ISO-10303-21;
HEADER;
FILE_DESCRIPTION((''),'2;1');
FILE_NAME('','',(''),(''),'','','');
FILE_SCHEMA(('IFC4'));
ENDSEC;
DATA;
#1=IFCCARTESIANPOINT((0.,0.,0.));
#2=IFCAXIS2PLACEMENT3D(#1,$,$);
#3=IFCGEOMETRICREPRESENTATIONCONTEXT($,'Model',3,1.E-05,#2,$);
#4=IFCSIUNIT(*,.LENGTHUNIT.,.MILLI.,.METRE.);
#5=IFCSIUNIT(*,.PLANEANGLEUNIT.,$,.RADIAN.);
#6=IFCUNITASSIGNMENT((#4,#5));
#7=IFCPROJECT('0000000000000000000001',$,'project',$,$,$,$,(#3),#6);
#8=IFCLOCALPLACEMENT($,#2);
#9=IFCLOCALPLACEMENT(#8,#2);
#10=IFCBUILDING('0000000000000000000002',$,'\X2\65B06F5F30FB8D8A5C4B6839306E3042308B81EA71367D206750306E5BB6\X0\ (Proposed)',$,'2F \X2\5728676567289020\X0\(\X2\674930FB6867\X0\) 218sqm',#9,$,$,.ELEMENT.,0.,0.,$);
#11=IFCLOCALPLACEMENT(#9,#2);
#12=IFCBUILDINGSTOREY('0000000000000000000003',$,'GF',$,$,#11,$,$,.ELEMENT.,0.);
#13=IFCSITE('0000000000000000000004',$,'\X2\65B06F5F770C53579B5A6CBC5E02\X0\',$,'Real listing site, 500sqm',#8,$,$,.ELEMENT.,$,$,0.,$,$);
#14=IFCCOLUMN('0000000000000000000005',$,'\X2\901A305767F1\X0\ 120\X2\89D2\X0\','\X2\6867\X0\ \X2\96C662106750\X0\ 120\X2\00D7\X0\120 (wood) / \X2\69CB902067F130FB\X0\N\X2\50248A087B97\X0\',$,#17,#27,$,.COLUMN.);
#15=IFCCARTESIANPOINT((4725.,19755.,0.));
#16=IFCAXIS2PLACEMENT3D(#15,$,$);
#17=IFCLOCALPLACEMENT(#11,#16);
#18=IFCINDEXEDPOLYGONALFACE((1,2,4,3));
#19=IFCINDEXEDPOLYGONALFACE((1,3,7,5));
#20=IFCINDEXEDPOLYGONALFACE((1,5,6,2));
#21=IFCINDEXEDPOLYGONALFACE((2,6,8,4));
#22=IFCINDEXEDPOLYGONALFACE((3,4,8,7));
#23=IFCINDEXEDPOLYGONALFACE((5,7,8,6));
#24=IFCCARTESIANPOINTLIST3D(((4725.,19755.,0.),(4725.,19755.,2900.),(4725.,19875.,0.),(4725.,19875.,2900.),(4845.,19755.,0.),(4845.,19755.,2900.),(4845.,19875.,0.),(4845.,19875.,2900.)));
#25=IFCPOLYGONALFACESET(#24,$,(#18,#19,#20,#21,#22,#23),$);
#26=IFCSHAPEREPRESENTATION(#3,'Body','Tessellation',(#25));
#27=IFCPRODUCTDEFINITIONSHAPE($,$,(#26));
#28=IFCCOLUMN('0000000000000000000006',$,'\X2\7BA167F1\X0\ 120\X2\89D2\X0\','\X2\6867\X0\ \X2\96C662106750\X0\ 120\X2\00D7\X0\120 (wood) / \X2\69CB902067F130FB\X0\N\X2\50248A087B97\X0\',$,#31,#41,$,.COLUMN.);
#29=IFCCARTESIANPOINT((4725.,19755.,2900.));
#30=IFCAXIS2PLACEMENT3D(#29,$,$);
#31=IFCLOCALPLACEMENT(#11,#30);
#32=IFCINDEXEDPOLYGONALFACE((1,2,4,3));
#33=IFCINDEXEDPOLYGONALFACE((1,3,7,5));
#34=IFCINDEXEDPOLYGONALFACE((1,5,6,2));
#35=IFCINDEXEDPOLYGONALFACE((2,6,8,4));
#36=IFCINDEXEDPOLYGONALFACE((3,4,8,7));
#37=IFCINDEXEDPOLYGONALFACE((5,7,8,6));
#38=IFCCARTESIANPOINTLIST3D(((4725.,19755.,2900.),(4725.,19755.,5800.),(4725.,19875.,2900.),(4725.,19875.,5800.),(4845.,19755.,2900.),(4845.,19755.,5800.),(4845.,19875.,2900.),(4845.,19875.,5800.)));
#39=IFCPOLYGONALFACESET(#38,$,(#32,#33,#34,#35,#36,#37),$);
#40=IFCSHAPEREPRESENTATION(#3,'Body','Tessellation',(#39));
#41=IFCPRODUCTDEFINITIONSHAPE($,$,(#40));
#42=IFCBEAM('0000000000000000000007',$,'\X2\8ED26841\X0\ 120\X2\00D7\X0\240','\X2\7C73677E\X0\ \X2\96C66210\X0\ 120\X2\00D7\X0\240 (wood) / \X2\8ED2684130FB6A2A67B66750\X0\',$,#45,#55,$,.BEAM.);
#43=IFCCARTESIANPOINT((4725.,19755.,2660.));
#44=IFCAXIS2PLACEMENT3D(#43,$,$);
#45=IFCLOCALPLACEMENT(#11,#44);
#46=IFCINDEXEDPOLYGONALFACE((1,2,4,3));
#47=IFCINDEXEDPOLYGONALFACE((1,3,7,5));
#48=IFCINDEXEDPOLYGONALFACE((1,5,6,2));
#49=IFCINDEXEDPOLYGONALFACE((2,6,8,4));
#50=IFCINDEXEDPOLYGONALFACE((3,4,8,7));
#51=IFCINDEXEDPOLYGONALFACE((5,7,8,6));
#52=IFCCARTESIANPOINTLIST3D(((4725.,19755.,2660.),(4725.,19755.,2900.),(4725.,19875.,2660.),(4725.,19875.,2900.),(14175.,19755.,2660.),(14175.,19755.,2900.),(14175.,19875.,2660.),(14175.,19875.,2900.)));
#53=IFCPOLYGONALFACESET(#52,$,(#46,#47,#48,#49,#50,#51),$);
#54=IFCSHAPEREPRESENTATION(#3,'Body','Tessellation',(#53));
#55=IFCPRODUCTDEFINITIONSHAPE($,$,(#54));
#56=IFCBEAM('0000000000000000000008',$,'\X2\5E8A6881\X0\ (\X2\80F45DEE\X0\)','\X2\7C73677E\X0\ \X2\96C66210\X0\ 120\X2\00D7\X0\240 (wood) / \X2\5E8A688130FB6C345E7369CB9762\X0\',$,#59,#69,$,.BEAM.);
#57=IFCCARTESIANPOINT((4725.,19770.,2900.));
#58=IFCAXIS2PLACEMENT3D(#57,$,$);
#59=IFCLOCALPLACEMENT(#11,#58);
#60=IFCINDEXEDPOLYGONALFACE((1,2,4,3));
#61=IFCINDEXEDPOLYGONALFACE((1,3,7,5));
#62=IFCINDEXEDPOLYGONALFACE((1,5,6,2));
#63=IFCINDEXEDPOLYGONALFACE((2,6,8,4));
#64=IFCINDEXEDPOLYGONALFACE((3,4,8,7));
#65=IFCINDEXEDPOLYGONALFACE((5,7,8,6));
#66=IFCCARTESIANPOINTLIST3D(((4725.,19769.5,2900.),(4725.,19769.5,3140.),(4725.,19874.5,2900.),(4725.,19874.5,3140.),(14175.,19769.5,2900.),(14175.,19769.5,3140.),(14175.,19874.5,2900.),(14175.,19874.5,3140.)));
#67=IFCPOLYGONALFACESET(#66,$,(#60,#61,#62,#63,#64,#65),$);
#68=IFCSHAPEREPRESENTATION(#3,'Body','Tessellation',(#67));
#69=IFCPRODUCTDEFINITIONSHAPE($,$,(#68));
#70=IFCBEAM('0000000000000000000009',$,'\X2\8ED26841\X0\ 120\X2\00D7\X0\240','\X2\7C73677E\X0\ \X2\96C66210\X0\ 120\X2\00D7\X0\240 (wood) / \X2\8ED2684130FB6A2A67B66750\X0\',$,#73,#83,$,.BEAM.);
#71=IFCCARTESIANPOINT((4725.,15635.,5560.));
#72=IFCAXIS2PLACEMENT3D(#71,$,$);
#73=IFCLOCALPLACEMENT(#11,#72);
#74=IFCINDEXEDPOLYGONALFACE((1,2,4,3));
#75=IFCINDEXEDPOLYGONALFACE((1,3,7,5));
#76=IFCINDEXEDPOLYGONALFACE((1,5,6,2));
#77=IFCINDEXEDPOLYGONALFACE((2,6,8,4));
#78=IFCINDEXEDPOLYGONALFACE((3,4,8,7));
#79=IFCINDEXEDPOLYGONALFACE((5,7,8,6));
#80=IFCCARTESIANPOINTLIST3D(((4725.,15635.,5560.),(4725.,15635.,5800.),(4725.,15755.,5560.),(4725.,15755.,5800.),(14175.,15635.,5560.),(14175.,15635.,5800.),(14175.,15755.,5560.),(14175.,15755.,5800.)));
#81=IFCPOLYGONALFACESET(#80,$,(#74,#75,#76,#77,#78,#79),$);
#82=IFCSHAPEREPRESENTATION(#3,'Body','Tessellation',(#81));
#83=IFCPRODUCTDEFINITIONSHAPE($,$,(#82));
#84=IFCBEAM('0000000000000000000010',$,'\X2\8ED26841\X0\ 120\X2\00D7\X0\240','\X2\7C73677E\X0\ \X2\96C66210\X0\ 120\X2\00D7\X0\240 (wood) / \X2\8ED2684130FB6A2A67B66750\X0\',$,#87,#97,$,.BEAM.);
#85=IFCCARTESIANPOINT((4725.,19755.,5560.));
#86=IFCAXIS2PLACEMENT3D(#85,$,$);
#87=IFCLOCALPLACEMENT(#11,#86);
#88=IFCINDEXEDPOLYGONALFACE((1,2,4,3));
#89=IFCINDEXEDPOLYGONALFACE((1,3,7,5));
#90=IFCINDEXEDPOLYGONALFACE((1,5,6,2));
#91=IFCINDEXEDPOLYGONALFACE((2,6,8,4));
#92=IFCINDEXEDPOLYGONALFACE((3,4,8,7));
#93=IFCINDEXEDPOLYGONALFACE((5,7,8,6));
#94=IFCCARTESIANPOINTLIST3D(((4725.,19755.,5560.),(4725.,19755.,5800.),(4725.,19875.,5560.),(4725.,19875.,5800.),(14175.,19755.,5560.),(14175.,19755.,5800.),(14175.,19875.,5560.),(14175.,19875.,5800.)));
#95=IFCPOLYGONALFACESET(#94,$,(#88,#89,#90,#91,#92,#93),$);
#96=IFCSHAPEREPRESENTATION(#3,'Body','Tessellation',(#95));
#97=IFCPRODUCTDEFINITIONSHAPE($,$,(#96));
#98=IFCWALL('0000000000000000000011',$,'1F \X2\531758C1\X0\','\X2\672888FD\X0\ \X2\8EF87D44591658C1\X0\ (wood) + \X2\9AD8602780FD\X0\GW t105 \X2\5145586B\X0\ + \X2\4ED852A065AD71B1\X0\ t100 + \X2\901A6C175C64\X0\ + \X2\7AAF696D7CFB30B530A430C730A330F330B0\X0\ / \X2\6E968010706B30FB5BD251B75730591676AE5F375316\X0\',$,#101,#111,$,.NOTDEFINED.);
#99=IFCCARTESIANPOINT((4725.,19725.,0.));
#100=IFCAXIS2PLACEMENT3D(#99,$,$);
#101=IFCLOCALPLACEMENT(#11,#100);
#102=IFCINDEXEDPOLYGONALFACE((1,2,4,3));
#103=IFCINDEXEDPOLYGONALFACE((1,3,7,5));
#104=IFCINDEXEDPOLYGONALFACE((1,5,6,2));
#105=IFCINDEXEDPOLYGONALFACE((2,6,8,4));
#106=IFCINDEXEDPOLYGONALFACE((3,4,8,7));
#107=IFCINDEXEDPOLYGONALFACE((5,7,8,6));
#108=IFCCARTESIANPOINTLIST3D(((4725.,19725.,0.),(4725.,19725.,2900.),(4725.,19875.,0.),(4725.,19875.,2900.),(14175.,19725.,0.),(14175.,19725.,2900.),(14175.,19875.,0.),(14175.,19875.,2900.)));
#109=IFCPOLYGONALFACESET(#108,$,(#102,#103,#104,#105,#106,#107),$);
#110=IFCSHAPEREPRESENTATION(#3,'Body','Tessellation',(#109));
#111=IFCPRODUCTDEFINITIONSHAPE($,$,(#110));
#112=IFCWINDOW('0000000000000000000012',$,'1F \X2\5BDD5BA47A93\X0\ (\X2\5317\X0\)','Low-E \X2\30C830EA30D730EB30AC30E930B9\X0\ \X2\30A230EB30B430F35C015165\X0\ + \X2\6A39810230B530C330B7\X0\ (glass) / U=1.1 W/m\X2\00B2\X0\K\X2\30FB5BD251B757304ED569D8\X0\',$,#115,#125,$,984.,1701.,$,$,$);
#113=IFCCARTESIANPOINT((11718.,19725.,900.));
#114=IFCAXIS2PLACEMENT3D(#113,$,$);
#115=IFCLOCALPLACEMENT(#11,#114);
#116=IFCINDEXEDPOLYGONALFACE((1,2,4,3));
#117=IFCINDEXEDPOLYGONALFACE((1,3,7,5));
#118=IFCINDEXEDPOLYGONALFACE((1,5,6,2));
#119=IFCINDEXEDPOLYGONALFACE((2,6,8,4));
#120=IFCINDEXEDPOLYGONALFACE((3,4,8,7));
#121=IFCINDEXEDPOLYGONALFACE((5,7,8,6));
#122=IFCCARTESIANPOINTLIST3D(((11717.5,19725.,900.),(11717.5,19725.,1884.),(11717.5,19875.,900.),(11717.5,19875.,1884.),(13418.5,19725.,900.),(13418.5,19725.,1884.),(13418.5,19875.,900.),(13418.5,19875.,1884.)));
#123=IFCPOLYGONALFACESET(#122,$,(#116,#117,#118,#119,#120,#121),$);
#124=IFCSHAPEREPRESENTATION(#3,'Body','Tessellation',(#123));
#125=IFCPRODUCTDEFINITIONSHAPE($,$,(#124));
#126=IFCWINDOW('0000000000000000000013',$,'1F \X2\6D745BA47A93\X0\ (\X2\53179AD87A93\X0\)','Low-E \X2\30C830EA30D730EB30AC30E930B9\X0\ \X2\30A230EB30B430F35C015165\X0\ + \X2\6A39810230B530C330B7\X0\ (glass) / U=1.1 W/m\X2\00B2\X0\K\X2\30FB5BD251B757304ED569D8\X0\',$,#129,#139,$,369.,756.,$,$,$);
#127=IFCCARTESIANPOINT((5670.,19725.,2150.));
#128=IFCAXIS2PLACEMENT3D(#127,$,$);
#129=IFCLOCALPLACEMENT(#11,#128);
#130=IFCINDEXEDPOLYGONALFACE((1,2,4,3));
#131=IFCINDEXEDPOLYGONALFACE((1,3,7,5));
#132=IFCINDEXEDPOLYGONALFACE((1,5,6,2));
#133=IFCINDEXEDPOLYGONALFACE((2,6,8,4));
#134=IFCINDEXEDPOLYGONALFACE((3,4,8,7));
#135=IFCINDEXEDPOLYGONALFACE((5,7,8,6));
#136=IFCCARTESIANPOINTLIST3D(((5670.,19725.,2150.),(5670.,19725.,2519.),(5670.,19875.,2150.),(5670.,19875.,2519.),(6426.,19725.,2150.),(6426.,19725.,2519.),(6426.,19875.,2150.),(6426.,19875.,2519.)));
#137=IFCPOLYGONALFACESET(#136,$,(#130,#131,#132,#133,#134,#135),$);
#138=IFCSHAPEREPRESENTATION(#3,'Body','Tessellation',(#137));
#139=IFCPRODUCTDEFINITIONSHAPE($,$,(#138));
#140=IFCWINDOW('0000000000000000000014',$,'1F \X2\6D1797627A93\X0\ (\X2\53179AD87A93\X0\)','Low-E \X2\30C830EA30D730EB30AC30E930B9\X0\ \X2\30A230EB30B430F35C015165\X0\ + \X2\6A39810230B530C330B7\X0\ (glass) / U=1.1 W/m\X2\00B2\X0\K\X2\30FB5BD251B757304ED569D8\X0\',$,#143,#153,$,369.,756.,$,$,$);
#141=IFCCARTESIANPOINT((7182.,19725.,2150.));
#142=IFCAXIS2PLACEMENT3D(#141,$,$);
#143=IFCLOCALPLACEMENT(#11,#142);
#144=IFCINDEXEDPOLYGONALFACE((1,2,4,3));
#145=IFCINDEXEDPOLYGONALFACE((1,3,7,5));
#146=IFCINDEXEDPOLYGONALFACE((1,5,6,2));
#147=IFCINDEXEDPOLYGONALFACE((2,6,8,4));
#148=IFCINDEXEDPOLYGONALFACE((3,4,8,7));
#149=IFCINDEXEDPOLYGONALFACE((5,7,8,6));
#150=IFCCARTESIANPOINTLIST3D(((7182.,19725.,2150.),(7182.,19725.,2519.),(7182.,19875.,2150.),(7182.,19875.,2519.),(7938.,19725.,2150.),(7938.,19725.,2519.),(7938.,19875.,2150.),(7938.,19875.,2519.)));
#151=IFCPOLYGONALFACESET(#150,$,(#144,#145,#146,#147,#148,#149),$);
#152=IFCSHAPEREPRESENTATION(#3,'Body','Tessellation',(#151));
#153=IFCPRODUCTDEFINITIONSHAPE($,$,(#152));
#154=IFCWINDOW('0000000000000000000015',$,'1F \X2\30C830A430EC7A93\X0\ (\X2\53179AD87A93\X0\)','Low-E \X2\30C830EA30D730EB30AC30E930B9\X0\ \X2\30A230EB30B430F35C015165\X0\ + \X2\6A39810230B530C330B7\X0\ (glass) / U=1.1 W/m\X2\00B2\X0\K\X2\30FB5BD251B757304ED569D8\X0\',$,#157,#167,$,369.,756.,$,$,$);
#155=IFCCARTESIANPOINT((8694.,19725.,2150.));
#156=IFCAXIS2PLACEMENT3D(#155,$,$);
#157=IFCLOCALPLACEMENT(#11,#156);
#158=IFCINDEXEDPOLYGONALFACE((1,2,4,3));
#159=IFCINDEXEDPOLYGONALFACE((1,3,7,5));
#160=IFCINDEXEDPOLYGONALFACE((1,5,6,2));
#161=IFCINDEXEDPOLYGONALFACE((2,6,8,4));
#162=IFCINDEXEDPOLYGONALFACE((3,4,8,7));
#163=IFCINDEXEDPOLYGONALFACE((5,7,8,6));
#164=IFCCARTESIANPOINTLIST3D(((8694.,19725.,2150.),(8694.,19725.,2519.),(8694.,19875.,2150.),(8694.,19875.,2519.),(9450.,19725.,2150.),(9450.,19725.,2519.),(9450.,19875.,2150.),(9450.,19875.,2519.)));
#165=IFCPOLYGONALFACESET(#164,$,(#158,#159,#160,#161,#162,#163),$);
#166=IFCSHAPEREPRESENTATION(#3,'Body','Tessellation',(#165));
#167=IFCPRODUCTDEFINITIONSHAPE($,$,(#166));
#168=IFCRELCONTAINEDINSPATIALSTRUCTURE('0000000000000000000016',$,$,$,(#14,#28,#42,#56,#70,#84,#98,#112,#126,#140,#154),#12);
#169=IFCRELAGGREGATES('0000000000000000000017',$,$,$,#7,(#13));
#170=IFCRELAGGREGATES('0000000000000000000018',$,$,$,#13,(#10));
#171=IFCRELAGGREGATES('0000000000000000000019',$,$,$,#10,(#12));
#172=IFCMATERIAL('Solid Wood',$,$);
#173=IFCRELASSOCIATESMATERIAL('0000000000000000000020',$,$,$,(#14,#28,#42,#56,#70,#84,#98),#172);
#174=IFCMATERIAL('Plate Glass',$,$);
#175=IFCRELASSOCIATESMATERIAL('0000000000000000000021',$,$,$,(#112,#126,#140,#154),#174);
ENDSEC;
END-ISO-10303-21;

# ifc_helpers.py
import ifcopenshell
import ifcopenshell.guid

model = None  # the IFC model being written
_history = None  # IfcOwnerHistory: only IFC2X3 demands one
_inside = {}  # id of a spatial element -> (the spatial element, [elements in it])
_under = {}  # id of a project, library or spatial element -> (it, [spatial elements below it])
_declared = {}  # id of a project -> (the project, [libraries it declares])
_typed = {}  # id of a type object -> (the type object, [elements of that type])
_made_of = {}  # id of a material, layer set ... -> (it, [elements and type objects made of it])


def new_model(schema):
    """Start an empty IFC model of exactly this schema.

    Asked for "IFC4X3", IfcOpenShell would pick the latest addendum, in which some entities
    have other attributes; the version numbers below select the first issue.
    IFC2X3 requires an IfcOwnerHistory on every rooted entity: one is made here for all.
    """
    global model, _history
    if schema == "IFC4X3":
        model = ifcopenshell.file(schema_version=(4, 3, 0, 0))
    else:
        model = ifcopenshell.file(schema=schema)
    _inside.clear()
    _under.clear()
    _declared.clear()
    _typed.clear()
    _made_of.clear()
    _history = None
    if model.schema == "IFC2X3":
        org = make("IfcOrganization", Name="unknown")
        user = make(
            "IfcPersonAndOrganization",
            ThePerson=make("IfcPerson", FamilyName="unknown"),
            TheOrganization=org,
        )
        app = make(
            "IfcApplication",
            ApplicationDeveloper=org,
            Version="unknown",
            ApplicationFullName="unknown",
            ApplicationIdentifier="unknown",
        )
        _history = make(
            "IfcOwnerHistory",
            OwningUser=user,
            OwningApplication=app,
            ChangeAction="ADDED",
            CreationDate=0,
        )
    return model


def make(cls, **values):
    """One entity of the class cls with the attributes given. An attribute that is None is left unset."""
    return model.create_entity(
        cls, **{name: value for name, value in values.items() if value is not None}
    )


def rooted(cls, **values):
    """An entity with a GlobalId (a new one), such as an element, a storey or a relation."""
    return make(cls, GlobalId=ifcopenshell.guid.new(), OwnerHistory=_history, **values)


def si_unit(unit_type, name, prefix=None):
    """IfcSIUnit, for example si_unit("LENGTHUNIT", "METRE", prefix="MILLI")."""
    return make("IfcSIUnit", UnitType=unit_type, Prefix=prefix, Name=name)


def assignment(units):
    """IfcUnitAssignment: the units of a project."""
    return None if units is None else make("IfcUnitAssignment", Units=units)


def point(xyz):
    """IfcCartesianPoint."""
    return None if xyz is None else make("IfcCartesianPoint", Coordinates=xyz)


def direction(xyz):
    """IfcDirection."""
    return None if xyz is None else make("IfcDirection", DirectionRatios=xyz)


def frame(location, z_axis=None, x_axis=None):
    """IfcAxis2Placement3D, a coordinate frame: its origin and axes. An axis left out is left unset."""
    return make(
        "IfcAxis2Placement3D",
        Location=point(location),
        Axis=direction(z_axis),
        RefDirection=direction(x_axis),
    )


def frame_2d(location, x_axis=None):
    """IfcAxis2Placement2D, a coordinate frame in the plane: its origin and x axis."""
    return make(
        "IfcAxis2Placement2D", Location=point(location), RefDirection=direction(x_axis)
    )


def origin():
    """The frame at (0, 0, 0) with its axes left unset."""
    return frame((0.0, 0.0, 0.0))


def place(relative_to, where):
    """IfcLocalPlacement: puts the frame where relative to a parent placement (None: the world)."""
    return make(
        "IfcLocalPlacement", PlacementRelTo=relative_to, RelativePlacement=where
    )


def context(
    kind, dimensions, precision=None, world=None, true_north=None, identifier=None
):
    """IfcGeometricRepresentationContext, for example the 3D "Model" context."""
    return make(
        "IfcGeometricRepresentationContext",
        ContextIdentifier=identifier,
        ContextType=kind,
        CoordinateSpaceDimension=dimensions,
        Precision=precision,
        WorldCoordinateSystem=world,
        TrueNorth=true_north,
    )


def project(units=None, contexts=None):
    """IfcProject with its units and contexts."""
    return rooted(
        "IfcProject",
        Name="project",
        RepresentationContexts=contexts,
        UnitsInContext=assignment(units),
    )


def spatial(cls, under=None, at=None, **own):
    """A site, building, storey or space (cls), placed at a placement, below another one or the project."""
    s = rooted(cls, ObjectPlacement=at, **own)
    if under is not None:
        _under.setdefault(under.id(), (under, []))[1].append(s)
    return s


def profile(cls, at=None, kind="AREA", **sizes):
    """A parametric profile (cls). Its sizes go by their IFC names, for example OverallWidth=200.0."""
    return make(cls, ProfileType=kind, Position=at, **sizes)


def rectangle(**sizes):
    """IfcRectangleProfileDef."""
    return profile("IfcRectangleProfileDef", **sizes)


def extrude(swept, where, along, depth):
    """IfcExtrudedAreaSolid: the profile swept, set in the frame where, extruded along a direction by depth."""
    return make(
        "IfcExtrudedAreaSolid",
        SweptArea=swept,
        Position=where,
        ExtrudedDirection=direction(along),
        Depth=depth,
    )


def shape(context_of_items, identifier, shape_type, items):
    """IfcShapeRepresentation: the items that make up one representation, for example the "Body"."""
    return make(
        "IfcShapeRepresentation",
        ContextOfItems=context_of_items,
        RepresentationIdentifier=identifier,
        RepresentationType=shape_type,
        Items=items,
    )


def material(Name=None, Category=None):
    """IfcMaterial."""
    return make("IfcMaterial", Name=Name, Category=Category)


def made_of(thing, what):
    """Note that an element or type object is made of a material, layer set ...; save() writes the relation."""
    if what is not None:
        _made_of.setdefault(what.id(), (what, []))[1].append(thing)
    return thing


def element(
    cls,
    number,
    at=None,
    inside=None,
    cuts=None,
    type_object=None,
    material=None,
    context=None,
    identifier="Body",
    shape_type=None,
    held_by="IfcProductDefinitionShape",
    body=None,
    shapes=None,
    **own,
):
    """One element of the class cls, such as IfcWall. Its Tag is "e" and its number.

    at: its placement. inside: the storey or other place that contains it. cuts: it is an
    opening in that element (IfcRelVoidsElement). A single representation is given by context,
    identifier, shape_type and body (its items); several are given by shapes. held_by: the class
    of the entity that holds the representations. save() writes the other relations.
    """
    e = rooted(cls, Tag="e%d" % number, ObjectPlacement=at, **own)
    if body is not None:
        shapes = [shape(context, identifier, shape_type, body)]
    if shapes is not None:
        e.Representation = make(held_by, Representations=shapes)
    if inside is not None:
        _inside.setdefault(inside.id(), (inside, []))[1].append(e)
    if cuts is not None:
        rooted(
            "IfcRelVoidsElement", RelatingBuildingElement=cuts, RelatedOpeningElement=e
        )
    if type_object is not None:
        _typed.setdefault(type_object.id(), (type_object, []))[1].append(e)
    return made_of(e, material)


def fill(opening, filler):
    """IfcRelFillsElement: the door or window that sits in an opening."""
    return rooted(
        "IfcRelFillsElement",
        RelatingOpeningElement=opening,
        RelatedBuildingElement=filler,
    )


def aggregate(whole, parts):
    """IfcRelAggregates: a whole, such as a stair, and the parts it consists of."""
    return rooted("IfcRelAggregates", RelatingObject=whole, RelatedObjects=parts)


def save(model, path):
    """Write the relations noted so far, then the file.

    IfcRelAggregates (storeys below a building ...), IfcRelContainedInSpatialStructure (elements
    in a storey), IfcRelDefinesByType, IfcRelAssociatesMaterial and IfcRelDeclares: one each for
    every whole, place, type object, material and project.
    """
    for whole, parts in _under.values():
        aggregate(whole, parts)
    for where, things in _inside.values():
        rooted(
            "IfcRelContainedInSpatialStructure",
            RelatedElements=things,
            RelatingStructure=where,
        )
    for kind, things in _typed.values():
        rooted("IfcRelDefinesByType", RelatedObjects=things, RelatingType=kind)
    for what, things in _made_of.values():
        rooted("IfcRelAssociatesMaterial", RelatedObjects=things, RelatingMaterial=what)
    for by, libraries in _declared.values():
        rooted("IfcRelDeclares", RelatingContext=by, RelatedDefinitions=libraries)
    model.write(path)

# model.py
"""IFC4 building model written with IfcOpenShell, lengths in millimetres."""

from ifc_helpers import new_model, si_unit, frame, frame_2d, origin, place, context, project, spatial, rectangle, extrude, material, element, fill, save


model = new_model("IFC4")

# Units and contexts
model_context = context("Model", 3, precision=1e-05, world=origin())
ifc_project = project(units=[si_unit("LENGTHUNIT", "METRE", prefix="MILLI"), si_unit("PLANEANGLEUNIT", "RADIAN")], contexts=[model_context])

# Site, building, storey
site_placement = place(None, origin())
site = spatial("IfcSite", under=ifc_project, at=site_placement, Name="新潟県南魚沼市", ObjectType="Real listing site, 500sqm", CompositionType="ELEMENT", RefElevation=0.0)
building_placement = place(site_placement, origin())
building = spatial("IfcBuilding", under=site, at=building_placement, Name="新潟・越屋根のある自然素材の家 (Proposed)", ObjectType="2F 在来木造(杉・桧) 218sqm", CompositionType="ELEMENT", ElevationOfRefHeight=0.0, ElevationOfTerrain=0.0)
storey_placement = place(building_placement, origin())
storey = spatial("IfcBuildingStorey", under=building, at=storey_placement, Name="GF", CompositionType="ELEMENT", Elevation=0.0)

# Columns
ifc_material_1 = material(Name="Solid Wood")
column_1_placement = place(storey_placement, frame((4725.0, 19755.0, 0.0)))
element("IfcColumn", 1, at=column_1_placement, inside=storey, material=ifc_material_1, Name="通し柱 120角", Description="桧 集成材 120×120 (wood) / 構造柱・N値計算", PredefinedType="COLUMN", context=model_context, shape_type="SweptSolid", body=[
    extrude(rectangle(XDim=120.0, YDim=120.0, at=frame_2d((60.0, 60.0))), frame((4725.0, 19755.0, 0.0)), (0.0, 0.0, 1.0), 2900.0),
])
column_2_placement = place(storey_placement, frame((4725.0, 19755.0, 2900.0)))
element("IfcColumn", 2, at=column_2_placement, inside=storey, material=ifc_material_1, Name="管柱 120角", Description="桧 集成材 120×120 (wood) / 構造柱・N値計算", PredefinedType="COLUMN", context=model_context, shape_type="SweptSolid", body=[
    extrude(rectangle(XDim=120.0, YDim=120.0, at=frame_2d((60.0, 60.0))), frame((4725.0, 19755.0, 2900.0)), (0.0, 0.0, 1.0), 2900.0),
])

# Beams
beam_1_placement = place(storey_placement, frame((4725.0, 19755.0, 2660.0)))
element("IfcBeam", 3, at=beam_1_placement, inside=storey, material=ifc_material_1, Name="軒桁 120×240", Description="米松 集成 120×240 (wood) / 軒桁・横架材", PredefinedType="BEAM", context=model_context, shape_type="SweptSolid", body=[
    extrude(rectangle(XDim=9450.0, YDim=120.0, at=frame_2d((4725.0, 60.0))), frame((4725.0, 19755.0, 2660.0)), (0.0, 0.0, 1.0), 240.0),
])
beam_2_placement = place(storey_placement, frame((4725.0, 19770.0, 2900.0)))
element("IfcBeam", 4, at=beam_2_placement, inside=storey, material=ifc_material_1, Name="床梁 (胴差)", Description="米松 集成 120×240 (wood) / 床梁・水平構面", PredefinedType="BEAM", context=model_context, shape_type="SweptSolid", body=[
    extrude(rectangle(XDim=9450.0, YDim=105.0, at=frame_2d((4725.0, 52.0))), frame((4725.0, 19770.0, 2900.0)), (0.0, 0.0, 1.0), 240.0),
])
beam_3_placement = place(storey_placement, frame((4725.0, 15635.0, 5560.0)))
element("IfcBeam", 5, at=beam_3_placement, inside=storey, material=ifc_material_1, Name="軒桁 120×240", Description="米松 集成 120×240 (wood) / 軒桁・横架材", PredefinedType="BEAM", context=model_context, shape_type="SweptSolid", body=[
    extrude(rectangle(XDim=9450.0, YDim=120.0, at=frame_2d((4725.0, 60.0))), frame((4725.0, 15635.0, 5560.0)), (0.0, 0.0, 1.0), 240.0),
])
beam_4_placement = place(storey_placement, frame((4725.0, 19755.0, 5560.0)))
element("IfcBeam", 6, at=beam_4_placement, inside=storey, material=ifc_material_1, Name="軒桁 120×240", Description="米松 集成 120×240 (wood) / 軒桁・横架材", PredefinedType="BEAM", context=model_context, shape_type="SweptSolid", body=[
    extrude(rectangle(XDim=9450.0, YDim=120.0, at=frame_2d((4725.0, 60.0))), frame((4725.0, 19755.0, 5560.0)), (0.0, 0.0, 1.0), 240.0),
])

# Wall, openings, windows
wall_1_placement = place(storey_placement, frame((4725.0, 19725.0, 0.0)))
wall_1 = element("IfcWall", 7, at=wall_1_placement, inside=storey, material=ifc_material_1, Name="1F 北壁", Description="木製 軸組外壁 (wood) + 高性能GW t105 充填 + 付加断熱 t100 + 通気層 + 窯業系サイディング / 準耐火・寒冷地外皮強化", PredefinedType="NOTDEFINED", context=model_context, shape_type="SweptSolid", body=[
    extrude(rectangle(XDim=9450.0, YDim=150.0, at=frame_2d((4725.0, 75.0))), frame((4725.0, 19725.0, 0.0)), (0.0, 0.0, 1.0), 2900.0),
])
opening_1_placement = place(storey_placement, frame((11718.0, 19725.0, 900.0)))
opening_1 = element("IfcOpeningElement", 8, at=opening_1_placement, cuts=wall_1, PredefinedType="NOTDEFINED", context=model_context, shape_type="SweptSolid", body=[
    extrude(rectangle(XDim=1701.0, YDim=150.0, at=frame_2d((850.0, 75.0))), frame((11718.0, 19725.0, 900.0)), (0.0, 0.0, 1.0), 984.0),
])
opening_2_placement = place(storey_placement, frame((5670.0, 19725.0, 2150.0)))
opening_2 = element("IfcOpeningElement", 9, at=opening_2_placement, cuts=wall_1, PredefinedType="NOTDEFINED", context=model_context, shape_type="SweptSolid", body=[
    extrude(rectangle(XDim=756.0, YDim=150.0, at=frame_2d((378.0, 75.0))), frame((5670.0, 19725.0, 2150.0)), (0.0, 0.0, 1.0), 369.0),
])
opening_3_placement = place(storey_placement, frame((7182.0, 19725.0, 2150.0)))
opening_3 = element("IfcOpeningElement", 10, at=opening_3_placement, cuts=wall_1, PredefinedType="NOTDEFINED", context=model_context, shape_type="SweptSolid", body=[
    extrude(rectangle(XDim=756.0, YDim=150.0, at=frame_2d((378.0, 75.0))), frame((7182.0, 19725.0, 2150.0)), (0.0, 0.0, 1.0), 369.0),
])
opening_4_placement = place(storey_placement, frame((8694.0, 19725.0, 2150.0)))
opening_4 = element("IfcOpeningElement", 11, at=opening_4_placement, cuts=wall_1, PredefinedType="NOTDEFINED", context=model_context, shape_type="SweptSolid", body=[
    extrude(rectangle(XDim=756.0, YDim=150.0, at=frame_2d((378.0, 75.0))), frame((8694.0, 19725.0, 2150.0)), (0.0, 0.0, 1.0), 369.0),
])
ifc_material_2 = material(Name="Plate Glass")
window_1_placement = place(storey_placement, frame((11718.0, 19725.0, 900.0)))
window_1 = element("IfcWindow", 12, at=window_1_placement, inside=storey, material=ifc_material_2, Name="1F 寝室窓 (北)", Description="Low-E トリプルガラス アルゴン封入 + 樹脂サッシ (glass) / U=1.1 W/m²K・寒冷地仕様", OverallHeight=984.0, OverallWidth=1701.0, context=model_context, shape_type="SweptSolid", body=[
    extrude(rectangle(XDim=1701.0, YDim=150.0, at=frame_2d((850.0, 75.0))), frame((11718.0, 19725.0, 900.0)), (0.0, 0.0, 1.0), 984.0),
])
fill(opening_1, window_1)
window_2_placement = place(storey_placement, frame((5670.0, 19725.0, 2150.0)))
window_2 = element("IfcWindow", 13, at=window_2_placement, inside=storey, material=ifc_material_2, Name="1F 浴室窓 (北高窓)", Description="Low-E トリプルガラス アルゴン封入 + 樹脂サッシ (glass) / U=1.1 W/m²K・寒冷地仕様", OverallHeight=369.0, OverallWidth=756.0, context=model_context, shape_type="SweptSolid", body=[
    extrude(rectangle(XDim=756.0, YDim=150.0, at=frame_2d((378.0, 75.0))), frame((5670.0, 19725.0, 2150.0)), (0.0, 0.0, 1.0), 369.0),
])
fill(opening_2, window_2)
window_3_placement = place(storey_placement, frame((7182.0, 19725.0, 2150.0)))
window_3 = element("IfcWindow", 14, at=window_3_placement, inside=storey, material=ifc_material_2, Name="1F 洗面窓 (北高窓)", Description="Low-E トリプルガラス アルゴン封入 + 樹脂サッシ (glass) / U=1.1 W/m²K・寒冷地仕様", OverallHeight=369.0, OverallWidth=756.0, context=model_context, shape_type="SweptSolid", body=[
    extrude(rectangle(XDim=756.0, YDim=150.0, at=frame_2d((378.0, 75.0))), frame((7182.0, 19725.0, 2150.0)), (0.0, 0.0, 1.0), 369.0),
])
fill(opening_3, window_3)
window_4_placement = place(storey_placement, frame((8694.0, 19725.0, 2150.0)))
window_4 = element("IfcWindow", 15, at=window_4_placement, inside=storey, material=ifc_material_2, Name="1F トイレ窓 (北高窓)", Description="Low-E トリプルガラス アルゴン封入 + 樹脂サッシ (glass) / U=1.1 W/m²K・寒冷地仕様", OverallHeight=369.0, OverallWidth=756.0, context=model_context, shape_type="SweptSolid", body=[
    extrude(rectangle(XDim=756.0, YDim=150.0, at=frame_2d((378.0, 75.0))), frame((8694.0, 19725.0, 2150.0)), (0.0, 0.0, 1.0), 369.0),
])
fill(opening_4, window_4)

save(model, "model.ifc")
